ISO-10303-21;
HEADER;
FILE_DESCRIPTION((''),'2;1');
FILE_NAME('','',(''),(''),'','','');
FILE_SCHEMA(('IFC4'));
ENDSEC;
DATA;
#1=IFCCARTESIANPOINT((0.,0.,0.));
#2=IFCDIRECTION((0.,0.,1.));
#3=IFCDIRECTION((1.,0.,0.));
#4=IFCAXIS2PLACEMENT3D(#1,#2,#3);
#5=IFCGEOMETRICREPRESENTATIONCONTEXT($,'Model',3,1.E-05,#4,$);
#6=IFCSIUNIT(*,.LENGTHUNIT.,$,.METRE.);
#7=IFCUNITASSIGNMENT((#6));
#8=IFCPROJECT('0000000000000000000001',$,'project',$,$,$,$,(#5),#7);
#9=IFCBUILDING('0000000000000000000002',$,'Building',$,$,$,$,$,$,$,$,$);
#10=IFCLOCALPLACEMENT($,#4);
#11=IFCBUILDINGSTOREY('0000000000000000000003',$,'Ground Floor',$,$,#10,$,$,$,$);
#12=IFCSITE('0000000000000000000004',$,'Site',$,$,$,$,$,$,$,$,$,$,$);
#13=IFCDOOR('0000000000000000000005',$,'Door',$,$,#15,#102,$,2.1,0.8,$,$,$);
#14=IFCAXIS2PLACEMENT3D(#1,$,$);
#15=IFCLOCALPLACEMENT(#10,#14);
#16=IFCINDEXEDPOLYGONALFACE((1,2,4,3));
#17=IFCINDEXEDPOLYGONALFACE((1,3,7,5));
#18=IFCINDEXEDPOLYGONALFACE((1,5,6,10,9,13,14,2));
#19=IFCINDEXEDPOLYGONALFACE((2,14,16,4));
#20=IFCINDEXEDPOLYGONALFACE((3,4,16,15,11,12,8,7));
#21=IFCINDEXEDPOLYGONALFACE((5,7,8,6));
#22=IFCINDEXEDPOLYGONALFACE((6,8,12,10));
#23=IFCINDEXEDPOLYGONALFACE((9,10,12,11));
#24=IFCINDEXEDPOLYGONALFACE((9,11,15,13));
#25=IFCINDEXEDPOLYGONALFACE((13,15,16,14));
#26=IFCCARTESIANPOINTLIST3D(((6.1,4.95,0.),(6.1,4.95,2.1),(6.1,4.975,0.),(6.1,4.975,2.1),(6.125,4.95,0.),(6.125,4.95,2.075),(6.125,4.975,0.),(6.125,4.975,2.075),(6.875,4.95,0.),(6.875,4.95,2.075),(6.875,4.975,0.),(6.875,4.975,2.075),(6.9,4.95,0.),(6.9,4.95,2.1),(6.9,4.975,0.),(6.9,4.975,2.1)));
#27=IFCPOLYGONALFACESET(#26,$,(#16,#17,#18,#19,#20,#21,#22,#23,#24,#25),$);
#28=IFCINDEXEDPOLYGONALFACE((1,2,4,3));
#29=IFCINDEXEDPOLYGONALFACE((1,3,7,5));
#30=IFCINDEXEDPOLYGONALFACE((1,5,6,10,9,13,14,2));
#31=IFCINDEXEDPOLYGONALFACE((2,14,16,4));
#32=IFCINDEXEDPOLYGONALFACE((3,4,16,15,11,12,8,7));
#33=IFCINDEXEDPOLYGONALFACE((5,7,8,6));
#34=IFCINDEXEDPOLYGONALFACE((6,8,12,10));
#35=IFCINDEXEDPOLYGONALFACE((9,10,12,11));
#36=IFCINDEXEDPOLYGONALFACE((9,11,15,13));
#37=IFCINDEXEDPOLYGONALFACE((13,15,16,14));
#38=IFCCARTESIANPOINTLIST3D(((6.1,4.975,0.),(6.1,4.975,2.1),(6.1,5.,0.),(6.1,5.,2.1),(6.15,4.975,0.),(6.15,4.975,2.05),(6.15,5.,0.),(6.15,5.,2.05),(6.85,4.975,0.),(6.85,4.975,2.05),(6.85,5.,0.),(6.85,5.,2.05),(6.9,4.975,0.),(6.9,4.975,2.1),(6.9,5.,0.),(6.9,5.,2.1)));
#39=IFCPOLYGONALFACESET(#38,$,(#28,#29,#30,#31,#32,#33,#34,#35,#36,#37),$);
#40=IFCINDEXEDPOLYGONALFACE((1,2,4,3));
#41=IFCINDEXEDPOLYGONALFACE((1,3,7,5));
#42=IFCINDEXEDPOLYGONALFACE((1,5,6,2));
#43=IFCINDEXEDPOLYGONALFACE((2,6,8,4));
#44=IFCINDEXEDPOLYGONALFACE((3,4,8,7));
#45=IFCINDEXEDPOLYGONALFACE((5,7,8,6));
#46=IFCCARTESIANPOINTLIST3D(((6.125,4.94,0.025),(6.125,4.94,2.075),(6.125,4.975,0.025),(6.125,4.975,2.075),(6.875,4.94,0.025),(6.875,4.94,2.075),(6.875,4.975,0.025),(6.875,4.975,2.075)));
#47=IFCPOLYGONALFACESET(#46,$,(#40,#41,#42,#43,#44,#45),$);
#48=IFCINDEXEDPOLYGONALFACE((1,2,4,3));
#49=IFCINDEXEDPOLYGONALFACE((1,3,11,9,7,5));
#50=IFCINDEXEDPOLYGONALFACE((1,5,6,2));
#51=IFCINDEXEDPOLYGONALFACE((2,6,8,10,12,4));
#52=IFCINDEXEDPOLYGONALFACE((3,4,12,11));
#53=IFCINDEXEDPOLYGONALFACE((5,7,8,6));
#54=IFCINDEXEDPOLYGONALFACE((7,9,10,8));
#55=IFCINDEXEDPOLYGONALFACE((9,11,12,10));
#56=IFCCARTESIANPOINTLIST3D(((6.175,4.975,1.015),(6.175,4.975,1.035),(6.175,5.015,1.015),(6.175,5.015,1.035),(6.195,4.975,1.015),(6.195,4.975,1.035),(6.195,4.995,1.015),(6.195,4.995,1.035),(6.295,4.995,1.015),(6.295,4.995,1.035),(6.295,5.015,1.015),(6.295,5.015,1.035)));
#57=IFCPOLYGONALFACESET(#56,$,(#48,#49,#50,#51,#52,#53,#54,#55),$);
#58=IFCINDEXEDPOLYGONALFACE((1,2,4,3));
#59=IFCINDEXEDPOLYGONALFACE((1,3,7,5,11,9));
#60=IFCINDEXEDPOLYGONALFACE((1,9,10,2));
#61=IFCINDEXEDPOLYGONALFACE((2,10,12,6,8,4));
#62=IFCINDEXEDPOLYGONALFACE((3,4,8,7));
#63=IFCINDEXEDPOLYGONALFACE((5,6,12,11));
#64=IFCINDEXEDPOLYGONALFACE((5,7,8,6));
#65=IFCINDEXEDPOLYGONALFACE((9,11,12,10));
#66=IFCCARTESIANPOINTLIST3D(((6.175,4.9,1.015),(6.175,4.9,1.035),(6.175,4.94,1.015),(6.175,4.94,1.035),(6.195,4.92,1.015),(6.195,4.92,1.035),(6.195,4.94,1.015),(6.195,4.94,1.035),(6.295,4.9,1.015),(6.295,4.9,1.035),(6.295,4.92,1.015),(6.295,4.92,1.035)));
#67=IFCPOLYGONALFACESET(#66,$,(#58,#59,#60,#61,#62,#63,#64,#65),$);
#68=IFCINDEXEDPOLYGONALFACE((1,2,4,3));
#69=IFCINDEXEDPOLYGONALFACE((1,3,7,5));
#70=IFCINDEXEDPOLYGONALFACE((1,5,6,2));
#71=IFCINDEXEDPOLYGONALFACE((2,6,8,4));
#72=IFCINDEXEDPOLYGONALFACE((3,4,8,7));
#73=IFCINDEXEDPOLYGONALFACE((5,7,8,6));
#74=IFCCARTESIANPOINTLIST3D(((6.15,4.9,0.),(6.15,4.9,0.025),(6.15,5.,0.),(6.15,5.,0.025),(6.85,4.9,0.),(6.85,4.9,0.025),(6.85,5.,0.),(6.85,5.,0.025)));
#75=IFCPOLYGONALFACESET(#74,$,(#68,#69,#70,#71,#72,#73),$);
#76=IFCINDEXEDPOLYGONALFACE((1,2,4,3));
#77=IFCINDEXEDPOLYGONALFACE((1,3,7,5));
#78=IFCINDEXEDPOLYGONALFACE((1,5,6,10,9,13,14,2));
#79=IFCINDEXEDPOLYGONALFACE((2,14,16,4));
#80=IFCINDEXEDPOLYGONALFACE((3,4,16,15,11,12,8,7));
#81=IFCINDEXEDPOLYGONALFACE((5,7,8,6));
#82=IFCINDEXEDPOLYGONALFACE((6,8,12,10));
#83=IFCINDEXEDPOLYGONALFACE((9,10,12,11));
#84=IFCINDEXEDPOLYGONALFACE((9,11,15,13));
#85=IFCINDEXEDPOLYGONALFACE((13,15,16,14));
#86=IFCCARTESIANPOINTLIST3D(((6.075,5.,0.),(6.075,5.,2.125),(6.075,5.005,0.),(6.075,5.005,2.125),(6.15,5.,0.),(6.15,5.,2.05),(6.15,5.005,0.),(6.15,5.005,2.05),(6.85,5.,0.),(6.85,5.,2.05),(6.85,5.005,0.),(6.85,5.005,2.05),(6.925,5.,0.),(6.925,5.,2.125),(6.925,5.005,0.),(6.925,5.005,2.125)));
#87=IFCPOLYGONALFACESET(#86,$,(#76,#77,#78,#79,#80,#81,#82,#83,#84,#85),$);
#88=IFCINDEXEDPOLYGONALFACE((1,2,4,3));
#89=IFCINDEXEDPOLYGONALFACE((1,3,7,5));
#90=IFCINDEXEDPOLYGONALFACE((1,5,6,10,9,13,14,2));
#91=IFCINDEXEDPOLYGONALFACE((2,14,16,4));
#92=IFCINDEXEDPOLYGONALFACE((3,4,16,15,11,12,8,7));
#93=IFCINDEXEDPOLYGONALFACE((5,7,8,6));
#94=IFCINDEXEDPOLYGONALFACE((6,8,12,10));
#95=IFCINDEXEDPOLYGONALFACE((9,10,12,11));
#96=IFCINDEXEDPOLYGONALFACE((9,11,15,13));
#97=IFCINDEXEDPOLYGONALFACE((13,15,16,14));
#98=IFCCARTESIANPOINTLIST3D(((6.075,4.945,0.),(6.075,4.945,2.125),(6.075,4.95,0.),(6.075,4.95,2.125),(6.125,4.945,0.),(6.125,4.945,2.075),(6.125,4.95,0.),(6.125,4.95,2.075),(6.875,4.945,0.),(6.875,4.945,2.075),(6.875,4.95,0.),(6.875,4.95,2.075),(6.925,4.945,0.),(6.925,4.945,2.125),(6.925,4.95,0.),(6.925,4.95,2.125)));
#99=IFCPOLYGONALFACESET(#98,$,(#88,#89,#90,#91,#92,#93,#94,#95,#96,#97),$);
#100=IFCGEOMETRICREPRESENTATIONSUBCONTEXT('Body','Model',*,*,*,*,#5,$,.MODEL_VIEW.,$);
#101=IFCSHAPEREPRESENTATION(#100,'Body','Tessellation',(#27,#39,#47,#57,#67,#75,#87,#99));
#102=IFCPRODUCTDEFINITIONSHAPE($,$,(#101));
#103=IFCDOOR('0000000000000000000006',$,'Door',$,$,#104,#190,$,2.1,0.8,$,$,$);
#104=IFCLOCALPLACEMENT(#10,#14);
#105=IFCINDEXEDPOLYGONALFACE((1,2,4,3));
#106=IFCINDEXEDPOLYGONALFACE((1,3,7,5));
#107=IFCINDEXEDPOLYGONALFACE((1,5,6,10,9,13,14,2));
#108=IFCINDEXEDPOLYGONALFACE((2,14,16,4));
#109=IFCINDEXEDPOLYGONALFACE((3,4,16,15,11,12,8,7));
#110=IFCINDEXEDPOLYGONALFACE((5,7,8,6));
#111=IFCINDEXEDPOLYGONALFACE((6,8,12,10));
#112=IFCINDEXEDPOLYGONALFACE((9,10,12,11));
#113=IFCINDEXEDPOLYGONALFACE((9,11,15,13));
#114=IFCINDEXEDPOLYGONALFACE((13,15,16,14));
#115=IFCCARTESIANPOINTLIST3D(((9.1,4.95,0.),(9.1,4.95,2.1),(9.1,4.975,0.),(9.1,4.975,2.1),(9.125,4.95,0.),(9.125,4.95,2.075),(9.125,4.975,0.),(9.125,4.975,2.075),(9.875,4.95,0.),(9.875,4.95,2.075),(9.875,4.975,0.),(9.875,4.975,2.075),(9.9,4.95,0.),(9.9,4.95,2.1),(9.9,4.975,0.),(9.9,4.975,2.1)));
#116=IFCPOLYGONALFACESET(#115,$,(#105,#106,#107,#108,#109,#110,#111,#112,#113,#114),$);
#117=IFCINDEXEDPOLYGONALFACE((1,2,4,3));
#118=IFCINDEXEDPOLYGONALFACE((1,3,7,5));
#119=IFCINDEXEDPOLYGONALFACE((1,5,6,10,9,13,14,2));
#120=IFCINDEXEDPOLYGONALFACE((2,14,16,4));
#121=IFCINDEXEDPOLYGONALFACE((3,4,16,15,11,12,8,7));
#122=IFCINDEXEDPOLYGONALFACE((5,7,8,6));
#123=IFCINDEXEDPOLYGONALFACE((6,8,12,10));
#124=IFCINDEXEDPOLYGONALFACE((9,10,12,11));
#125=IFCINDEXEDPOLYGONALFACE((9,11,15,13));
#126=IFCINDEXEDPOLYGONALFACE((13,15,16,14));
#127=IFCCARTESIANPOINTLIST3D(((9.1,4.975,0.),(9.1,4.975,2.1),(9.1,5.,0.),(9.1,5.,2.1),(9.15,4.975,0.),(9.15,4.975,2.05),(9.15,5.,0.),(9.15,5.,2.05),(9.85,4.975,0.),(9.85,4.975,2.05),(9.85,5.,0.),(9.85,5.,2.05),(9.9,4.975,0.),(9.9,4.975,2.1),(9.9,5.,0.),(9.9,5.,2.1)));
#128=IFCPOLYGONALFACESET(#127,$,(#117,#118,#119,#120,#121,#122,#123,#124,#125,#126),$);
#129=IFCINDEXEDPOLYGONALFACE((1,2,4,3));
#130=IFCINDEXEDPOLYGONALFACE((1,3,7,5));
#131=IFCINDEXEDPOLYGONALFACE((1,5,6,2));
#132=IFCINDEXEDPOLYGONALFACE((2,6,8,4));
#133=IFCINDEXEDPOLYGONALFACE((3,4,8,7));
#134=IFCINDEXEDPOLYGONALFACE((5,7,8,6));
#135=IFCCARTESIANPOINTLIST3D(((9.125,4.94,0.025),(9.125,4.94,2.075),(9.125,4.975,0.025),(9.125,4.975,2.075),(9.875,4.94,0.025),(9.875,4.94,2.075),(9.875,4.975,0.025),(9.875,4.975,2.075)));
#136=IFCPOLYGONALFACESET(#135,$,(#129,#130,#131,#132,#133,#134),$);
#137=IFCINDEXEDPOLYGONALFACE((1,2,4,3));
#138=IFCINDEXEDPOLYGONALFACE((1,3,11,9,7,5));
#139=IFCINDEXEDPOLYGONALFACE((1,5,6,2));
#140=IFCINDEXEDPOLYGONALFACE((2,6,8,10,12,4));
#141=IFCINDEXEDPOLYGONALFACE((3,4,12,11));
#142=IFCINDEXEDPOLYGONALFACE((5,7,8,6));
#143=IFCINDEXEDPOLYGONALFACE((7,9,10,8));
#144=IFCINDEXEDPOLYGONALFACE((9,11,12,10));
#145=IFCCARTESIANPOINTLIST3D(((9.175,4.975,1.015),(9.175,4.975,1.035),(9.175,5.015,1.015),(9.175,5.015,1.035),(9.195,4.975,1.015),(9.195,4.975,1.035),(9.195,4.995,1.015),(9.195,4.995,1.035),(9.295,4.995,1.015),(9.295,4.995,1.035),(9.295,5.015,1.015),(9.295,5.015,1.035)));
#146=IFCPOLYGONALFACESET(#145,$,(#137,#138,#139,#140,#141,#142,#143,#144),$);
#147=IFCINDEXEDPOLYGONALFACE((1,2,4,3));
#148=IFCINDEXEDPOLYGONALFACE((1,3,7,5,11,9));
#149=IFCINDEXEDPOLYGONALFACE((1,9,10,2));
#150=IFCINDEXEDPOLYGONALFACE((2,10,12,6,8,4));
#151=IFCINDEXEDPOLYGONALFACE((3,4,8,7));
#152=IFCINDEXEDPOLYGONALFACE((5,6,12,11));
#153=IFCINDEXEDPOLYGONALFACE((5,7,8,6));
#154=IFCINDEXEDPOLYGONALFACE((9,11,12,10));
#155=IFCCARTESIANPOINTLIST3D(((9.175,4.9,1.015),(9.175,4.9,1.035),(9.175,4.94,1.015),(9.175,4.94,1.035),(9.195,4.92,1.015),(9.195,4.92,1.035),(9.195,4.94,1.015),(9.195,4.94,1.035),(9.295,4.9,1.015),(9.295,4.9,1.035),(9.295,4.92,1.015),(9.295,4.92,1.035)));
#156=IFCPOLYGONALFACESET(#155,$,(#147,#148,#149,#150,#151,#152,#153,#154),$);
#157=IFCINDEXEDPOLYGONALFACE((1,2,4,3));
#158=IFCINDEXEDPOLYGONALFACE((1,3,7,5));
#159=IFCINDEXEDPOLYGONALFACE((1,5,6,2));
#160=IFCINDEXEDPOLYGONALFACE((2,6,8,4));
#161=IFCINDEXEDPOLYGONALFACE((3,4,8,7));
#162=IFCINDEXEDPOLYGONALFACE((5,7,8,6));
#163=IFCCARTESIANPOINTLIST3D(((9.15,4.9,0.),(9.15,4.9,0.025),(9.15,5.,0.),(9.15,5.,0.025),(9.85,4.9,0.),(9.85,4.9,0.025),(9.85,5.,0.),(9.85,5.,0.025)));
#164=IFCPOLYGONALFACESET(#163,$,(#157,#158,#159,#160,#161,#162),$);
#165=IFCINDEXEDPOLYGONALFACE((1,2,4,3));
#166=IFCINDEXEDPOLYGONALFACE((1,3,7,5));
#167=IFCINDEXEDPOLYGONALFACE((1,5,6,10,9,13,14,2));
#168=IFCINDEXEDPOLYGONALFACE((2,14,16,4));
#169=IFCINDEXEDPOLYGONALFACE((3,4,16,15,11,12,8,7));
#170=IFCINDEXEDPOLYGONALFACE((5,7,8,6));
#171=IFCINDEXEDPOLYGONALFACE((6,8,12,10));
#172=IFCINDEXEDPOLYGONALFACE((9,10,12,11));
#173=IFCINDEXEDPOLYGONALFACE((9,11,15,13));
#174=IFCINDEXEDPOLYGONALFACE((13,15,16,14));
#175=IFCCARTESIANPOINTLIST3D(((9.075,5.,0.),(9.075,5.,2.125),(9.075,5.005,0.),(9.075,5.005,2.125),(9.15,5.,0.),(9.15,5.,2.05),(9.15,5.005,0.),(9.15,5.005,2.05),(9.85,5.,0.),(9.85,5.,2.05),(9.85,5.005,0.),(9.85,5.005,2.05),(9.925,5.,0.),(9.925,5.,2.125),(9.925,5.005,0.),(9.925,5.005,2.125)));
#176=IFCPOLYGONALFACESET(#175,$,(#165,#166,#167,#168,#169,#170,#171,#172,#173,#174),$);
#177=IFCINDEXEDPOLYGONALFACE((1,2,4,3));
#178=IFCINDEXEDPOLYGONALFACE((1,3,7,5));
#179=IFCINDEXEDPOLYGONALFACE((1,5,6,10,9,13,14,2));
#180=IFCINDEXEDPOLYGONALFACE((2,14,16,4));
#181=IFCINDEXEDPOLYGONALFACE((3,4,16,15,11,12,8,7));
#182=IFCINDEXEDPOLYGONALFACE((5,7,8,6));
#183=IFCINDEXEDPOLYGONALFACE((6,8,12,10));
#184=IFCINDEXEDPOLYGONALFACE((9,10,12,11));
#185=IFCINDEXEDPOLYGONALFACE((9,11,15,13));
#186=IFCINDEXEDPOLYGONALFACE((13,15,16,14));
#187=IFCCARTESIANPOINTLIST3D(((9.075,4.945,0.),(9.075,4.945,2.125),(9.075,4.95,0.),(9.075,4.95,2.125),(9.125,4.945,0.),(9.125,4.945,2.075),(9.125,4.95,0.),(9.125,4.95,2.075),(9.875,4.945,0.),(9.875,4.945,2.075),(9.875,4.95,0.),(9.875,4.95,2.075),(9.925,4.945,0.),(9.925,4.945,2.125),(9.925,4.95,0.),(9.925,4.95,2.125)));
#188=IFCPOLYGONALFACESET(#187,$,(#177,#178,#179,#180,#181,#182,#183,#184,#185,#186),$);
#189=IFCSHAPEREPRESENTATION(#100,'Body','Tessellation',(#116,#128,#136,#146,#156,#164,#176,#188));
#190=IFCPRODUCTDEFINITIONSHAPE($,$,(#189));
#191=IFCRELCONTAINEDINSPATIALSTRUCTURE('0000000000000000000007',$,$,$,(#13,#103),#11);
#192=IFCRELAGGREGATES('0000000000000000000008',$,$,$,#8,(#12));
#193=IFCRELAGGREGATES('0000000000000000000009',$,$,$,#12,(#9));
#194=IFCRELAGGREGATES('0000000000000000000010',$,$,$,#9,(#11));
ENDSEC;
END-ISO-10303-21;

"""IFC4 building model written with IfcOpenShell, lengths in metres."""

from ifc_helpers import new_model, si_unit, frame, origin_with_axes, place, context, subcontext, project, spatial, line, indexed_curve, outline, extrude, element, save


model = new_model("IFC4")

# Units and contexts
model_context = context("Model", 3, precision=1e-05, world=origin_with_axes())
body_context = subcontext(model_context, "Body", "Model", "MODEL_VIEW")
ifc_project = project(units=[si_unit("LENGTHUNIT", "METRE")], contexts=[model_context])

# Site, building, storey
site = spatial("IfcSite", under=ifc_project, Name="Site")
building = spatial("IfcBuilding", under=site, Name="Building")
storey_placement = place(None, origin_with_axes())
storey = spatial("IfcBuildingStorey", under=building, at=storey_placement, Name="Ground Floor")

# Doors
door_1_placement = place(storey_placement, frame((6.9, 5.0, 0.0), z_axis=(0.0, 0.0, 1.0), x_axis=(-1.0, 0.0, 0.0)))
element("IfcDoor", 1, at=door_1_placement, inside=storey, Name="Door", OverallHeight=2.1, OverallWidth=0.8, context=body_context, shape_type="SweptSolid", body=[
    extrude(outline(indexed_curve([(0.0, 0.0), (0.0, 2.1), (0.8, 2.1), (0.8, 0.0), (0.775, 0.0), (0.775, 2.075), (0.025, 2.075), (0.025, 0.0)], segments=[line(1, 2, 3, 4, 5, 6, 7, 8, 1)])), frame((0.0, 0.025, 0.0), z_axis=(0.0, -1.0, 0.0), x_axis=(1.0, 0.0, 0.0)), (0.0, 0.0, -1.0), 0.025),
    extrude(outline(indexed_curve([(0.0, 0.0), (0.0, 2.1), (0.8, 2.1), (0.8, 0.0), (0.75, 0.0), (0.75, 2.05), (0.05, 2.05), (0.05, 0.0)], segments=[line(1, 2, 3, 4, 5, 6, 7, 8, 1)])), frame((0.0, 0.0, 0.0), z_axis=(0.0, -1.0, 0.0), x_axis=(1.0, 0.0, 0.0)), (0.0, 0.0, -1.0), 0.025),
    extrude(outline(indexed_curve([(0.0, 0.0), (0.75, 0.0), (0.75, 0.035), (0.0, 0.035)], segments=[line(1, 2, 3, 4, 1)])), frame((0.025, 0.025, 0.025), z_axis=(0.0, 0.0, 1.0), x_axis=(1.0, 0.0, 0.0)), (0.0, 0.0, 1.0), 2.05),
    extrude(outline(indexed_curve([(0.0, 0.0), (0.0, -0.04), (-0.12, -0.04), (-0.12, -0.02), (-0.02, -0.02), (-0.02, 0.0)], segments=[line(1, 2, 3, 4, 5, 6, 1)])), frame((0.725, 0.025, 1.015), z_axis=(0.0, 0.0, 1.0), x_axis=(1.0, 0.0, 0.0)), (0.0, 0.0, 1.0), 0.02),
    extrude(outline(indexed_curve([(0.0, 0.0), (0.0, 0.04), (-0.12, 0.04), (-0.12, 0.02), (-0.02, 0.02), (-0.02, 0.0)], segments=[line(1, 2, 3, 4, 5, 6, 1)])), frame((0.725, 0.06, 1.015), z_axis=(0.0, 0.0, 1.0), x_axis=(1.0, 0.0, 0.0)), (0.0, 0.0, 1.0), 0.02),
    extrude(outline(indexed_curve([(0.0, 0.0), (0.7, 0.0), (0.7, 0.1), (0.0, 0.1)], segments=[line(1, 2, 3, 4, 1)])), frame((0.05, 0.0, 0.0), z_axis=(0.0, 0.0, 1.0), x_axis=(1.0, 0.0, 0.0)), (0.0, 0.0, 1.0), 0.025),
    extrude(outline(indexed_curve([(0.0, 0.0), (0.0, 2.125), (0.85, 2.125), (0.85, 0.0), (0.775, 0.0), (0.775, 2.05), (0.075, 2.05), (0.075, 0.0)], segments=[line(1, 2, 3, 4, 5, 6, 7, 8, 1)])), frame((-0.025, -0.005, 0.0), z_axis=(0.0, -1.0, 0.0), x_axis=(1.0, 0.0, 0.0)), (0.0, 0.0, -1.0), 0.005),
    extrude(outline(indexed_curve([(0.0, 0.0), (0.0, 2.125), (0.85, 2.125), (0.85, 0.0), (0.8, 0.0), (0.8, 2.075), (0.05, 2.075), (0.05, 0.0)], segments=[line(1, 2, 3, 4, 5, 6, 7, 8, 1)])), frame((-0.025, 0.05, 0.0), z_axis=(0.0, -1.0, 0.0), x_axis=(1.0, 0.0, 0.0)), (0.0, 0.0, -1.0), 0.005),
])
door_2_placement = place(storey_placement, frame((9.9, 5.0, 0.0), z_axis=(0.0, 0.0, 1.0), x_axis=(-1.0, 0.0, 0.0)))
element("IfcDoor", 2, at=door_2_placement, inside=storey, Name="Door", OverallHeight=2.1, OverallWidth=0.8, context=body_context, shape_type="SweptSolid", body=[
    extrude(outline(indexed_curve([(0.0, 0.0), (0.0, 2.1), (0.8, 2.1), (0.8, 0.0), (0.775, 0.0), (0.775, 2.075), (0.025, 2.075), (0.025, 0.0)], segments=[line(1, 2, 3, 4, 5, 6, 7, 8, 1)])), frame((0.0, 0.025, 0.0), z_axis=(0.0, -1.0, 0.0), x_axis=(1.0, 0.0, 0.0)), (0.0, 0.0, -1.0), 0.025),
    extrude(outline(indexed_curve([(0.0, 0.0), (0.0, 2.1), (0.8, 2.1), (0.8, 0.0), (0.75, 0.0), (0.75, 2.05), (0.05, 2.05), (0.05, 0.0)], segments=[line(1, 2, 3, 4, 5, 6, 7, 8, 1)])), frame((0.0, 0.0, 0.0), z_axis=(0.0, -1.0, 0.0), x_axis=(1.0, 0.0, 0.0)), (0.0, 0.0, -1.0), 0.025),
    extrude(outline(indexed_curve([(0.0, 0.0), (0.75, 0.0), (0.75, 0.035), (0.0, 0.035)], segments=[line(1, 2, 3, 4, 1)])), frame((0.025, 0.025, 0.025), z_axis=(0.0, 0.0, 1.0), x_axis=(1.0, 0.0, 0.0)), (0.0, 0.0, 1.0), 2.05),
    extrude(outline(indexed_curve([(0.0, 0.0), (0.0, -0.04), (-0.12, -0.04), (-0.12, -0.02), (-0.02, -0.02), (-0.02, 0.0)], segments=[line(1, 2, 3, 4, 5, 6, 1)])), frame((0.725, 0.025, 1.015), z_axis=(0.0, 0.0, 1.0), x_axis=(1.0, 0.0, 0.0)), (0.0, 0.0, 1.0), 0.02),
    extrude(outline(indexed_curve([(0.0, 0.0), (0.0, 0.04), (-0.12, 0.04), (-0.12, 0.02), (-0.02, 0.02), (-0.02, 0.0)], segments=[line(1, 2, 3, 4, 5, 6, 1)])), frame((0.725, 0.06, 1.015), z_axis=(0.0, 0.0, 1.0), x_axis=(1.0, 0.0, 0.0)), (0.0, 0.0, 1.0), 0.02),
    extrude(outline(indexed_curve([(0.0, 0.0), (0.7, 0.0), (0.7, 0.1), (0.0, 0.1)], segments=[line(1, 2, 3, 4, 1)])), frame((0.05, 0.0, 0.0), z_axis=(0.0, 0.0, 1.0), x_axis=(1.0, 0.0, 0.0)), (0.0, 0.0, 1.0), 0.025),
    extrude(outline(indexed_curve([(0.0, 0.0), (0.0, 2.125), (0.85, 2.125), (0.85, 0.0), (0.775, 0.0), (0.775, 2.05), (0.075, 2.05), (0.075, 0.0)], segments=[line(1, 2, 3, 4, 5, 6, 7, 8, 1)])), frame((-0.025, -0.005, 0.0), z_axis=(0.0, -1.0, 0.0), x_axis=(1.0, 0.0, 0.0)), (0.0, 0.0, -1.0), 0.005),
    extrude(outline(indexed_curve([(0.0, 0.0), (0.0, 2.125), (0.85, 2.125), (0.85, 0.0), (0.8, 0.0), (0.8, 2.075), (0.05, 2.075), (0.05, 0.0)], segments=[line(1, 2, 3, 4, 5, 6, 7, 8, 1)])), frame((-0.025, 0.05, 0.0), z_axis=(0.0, -1.0, 0.0), x_axis=(1.0, 0.0, 0.0)), (0.0, 0.0, -1.0), 0.005),
])

save(model, "model.ifc")
